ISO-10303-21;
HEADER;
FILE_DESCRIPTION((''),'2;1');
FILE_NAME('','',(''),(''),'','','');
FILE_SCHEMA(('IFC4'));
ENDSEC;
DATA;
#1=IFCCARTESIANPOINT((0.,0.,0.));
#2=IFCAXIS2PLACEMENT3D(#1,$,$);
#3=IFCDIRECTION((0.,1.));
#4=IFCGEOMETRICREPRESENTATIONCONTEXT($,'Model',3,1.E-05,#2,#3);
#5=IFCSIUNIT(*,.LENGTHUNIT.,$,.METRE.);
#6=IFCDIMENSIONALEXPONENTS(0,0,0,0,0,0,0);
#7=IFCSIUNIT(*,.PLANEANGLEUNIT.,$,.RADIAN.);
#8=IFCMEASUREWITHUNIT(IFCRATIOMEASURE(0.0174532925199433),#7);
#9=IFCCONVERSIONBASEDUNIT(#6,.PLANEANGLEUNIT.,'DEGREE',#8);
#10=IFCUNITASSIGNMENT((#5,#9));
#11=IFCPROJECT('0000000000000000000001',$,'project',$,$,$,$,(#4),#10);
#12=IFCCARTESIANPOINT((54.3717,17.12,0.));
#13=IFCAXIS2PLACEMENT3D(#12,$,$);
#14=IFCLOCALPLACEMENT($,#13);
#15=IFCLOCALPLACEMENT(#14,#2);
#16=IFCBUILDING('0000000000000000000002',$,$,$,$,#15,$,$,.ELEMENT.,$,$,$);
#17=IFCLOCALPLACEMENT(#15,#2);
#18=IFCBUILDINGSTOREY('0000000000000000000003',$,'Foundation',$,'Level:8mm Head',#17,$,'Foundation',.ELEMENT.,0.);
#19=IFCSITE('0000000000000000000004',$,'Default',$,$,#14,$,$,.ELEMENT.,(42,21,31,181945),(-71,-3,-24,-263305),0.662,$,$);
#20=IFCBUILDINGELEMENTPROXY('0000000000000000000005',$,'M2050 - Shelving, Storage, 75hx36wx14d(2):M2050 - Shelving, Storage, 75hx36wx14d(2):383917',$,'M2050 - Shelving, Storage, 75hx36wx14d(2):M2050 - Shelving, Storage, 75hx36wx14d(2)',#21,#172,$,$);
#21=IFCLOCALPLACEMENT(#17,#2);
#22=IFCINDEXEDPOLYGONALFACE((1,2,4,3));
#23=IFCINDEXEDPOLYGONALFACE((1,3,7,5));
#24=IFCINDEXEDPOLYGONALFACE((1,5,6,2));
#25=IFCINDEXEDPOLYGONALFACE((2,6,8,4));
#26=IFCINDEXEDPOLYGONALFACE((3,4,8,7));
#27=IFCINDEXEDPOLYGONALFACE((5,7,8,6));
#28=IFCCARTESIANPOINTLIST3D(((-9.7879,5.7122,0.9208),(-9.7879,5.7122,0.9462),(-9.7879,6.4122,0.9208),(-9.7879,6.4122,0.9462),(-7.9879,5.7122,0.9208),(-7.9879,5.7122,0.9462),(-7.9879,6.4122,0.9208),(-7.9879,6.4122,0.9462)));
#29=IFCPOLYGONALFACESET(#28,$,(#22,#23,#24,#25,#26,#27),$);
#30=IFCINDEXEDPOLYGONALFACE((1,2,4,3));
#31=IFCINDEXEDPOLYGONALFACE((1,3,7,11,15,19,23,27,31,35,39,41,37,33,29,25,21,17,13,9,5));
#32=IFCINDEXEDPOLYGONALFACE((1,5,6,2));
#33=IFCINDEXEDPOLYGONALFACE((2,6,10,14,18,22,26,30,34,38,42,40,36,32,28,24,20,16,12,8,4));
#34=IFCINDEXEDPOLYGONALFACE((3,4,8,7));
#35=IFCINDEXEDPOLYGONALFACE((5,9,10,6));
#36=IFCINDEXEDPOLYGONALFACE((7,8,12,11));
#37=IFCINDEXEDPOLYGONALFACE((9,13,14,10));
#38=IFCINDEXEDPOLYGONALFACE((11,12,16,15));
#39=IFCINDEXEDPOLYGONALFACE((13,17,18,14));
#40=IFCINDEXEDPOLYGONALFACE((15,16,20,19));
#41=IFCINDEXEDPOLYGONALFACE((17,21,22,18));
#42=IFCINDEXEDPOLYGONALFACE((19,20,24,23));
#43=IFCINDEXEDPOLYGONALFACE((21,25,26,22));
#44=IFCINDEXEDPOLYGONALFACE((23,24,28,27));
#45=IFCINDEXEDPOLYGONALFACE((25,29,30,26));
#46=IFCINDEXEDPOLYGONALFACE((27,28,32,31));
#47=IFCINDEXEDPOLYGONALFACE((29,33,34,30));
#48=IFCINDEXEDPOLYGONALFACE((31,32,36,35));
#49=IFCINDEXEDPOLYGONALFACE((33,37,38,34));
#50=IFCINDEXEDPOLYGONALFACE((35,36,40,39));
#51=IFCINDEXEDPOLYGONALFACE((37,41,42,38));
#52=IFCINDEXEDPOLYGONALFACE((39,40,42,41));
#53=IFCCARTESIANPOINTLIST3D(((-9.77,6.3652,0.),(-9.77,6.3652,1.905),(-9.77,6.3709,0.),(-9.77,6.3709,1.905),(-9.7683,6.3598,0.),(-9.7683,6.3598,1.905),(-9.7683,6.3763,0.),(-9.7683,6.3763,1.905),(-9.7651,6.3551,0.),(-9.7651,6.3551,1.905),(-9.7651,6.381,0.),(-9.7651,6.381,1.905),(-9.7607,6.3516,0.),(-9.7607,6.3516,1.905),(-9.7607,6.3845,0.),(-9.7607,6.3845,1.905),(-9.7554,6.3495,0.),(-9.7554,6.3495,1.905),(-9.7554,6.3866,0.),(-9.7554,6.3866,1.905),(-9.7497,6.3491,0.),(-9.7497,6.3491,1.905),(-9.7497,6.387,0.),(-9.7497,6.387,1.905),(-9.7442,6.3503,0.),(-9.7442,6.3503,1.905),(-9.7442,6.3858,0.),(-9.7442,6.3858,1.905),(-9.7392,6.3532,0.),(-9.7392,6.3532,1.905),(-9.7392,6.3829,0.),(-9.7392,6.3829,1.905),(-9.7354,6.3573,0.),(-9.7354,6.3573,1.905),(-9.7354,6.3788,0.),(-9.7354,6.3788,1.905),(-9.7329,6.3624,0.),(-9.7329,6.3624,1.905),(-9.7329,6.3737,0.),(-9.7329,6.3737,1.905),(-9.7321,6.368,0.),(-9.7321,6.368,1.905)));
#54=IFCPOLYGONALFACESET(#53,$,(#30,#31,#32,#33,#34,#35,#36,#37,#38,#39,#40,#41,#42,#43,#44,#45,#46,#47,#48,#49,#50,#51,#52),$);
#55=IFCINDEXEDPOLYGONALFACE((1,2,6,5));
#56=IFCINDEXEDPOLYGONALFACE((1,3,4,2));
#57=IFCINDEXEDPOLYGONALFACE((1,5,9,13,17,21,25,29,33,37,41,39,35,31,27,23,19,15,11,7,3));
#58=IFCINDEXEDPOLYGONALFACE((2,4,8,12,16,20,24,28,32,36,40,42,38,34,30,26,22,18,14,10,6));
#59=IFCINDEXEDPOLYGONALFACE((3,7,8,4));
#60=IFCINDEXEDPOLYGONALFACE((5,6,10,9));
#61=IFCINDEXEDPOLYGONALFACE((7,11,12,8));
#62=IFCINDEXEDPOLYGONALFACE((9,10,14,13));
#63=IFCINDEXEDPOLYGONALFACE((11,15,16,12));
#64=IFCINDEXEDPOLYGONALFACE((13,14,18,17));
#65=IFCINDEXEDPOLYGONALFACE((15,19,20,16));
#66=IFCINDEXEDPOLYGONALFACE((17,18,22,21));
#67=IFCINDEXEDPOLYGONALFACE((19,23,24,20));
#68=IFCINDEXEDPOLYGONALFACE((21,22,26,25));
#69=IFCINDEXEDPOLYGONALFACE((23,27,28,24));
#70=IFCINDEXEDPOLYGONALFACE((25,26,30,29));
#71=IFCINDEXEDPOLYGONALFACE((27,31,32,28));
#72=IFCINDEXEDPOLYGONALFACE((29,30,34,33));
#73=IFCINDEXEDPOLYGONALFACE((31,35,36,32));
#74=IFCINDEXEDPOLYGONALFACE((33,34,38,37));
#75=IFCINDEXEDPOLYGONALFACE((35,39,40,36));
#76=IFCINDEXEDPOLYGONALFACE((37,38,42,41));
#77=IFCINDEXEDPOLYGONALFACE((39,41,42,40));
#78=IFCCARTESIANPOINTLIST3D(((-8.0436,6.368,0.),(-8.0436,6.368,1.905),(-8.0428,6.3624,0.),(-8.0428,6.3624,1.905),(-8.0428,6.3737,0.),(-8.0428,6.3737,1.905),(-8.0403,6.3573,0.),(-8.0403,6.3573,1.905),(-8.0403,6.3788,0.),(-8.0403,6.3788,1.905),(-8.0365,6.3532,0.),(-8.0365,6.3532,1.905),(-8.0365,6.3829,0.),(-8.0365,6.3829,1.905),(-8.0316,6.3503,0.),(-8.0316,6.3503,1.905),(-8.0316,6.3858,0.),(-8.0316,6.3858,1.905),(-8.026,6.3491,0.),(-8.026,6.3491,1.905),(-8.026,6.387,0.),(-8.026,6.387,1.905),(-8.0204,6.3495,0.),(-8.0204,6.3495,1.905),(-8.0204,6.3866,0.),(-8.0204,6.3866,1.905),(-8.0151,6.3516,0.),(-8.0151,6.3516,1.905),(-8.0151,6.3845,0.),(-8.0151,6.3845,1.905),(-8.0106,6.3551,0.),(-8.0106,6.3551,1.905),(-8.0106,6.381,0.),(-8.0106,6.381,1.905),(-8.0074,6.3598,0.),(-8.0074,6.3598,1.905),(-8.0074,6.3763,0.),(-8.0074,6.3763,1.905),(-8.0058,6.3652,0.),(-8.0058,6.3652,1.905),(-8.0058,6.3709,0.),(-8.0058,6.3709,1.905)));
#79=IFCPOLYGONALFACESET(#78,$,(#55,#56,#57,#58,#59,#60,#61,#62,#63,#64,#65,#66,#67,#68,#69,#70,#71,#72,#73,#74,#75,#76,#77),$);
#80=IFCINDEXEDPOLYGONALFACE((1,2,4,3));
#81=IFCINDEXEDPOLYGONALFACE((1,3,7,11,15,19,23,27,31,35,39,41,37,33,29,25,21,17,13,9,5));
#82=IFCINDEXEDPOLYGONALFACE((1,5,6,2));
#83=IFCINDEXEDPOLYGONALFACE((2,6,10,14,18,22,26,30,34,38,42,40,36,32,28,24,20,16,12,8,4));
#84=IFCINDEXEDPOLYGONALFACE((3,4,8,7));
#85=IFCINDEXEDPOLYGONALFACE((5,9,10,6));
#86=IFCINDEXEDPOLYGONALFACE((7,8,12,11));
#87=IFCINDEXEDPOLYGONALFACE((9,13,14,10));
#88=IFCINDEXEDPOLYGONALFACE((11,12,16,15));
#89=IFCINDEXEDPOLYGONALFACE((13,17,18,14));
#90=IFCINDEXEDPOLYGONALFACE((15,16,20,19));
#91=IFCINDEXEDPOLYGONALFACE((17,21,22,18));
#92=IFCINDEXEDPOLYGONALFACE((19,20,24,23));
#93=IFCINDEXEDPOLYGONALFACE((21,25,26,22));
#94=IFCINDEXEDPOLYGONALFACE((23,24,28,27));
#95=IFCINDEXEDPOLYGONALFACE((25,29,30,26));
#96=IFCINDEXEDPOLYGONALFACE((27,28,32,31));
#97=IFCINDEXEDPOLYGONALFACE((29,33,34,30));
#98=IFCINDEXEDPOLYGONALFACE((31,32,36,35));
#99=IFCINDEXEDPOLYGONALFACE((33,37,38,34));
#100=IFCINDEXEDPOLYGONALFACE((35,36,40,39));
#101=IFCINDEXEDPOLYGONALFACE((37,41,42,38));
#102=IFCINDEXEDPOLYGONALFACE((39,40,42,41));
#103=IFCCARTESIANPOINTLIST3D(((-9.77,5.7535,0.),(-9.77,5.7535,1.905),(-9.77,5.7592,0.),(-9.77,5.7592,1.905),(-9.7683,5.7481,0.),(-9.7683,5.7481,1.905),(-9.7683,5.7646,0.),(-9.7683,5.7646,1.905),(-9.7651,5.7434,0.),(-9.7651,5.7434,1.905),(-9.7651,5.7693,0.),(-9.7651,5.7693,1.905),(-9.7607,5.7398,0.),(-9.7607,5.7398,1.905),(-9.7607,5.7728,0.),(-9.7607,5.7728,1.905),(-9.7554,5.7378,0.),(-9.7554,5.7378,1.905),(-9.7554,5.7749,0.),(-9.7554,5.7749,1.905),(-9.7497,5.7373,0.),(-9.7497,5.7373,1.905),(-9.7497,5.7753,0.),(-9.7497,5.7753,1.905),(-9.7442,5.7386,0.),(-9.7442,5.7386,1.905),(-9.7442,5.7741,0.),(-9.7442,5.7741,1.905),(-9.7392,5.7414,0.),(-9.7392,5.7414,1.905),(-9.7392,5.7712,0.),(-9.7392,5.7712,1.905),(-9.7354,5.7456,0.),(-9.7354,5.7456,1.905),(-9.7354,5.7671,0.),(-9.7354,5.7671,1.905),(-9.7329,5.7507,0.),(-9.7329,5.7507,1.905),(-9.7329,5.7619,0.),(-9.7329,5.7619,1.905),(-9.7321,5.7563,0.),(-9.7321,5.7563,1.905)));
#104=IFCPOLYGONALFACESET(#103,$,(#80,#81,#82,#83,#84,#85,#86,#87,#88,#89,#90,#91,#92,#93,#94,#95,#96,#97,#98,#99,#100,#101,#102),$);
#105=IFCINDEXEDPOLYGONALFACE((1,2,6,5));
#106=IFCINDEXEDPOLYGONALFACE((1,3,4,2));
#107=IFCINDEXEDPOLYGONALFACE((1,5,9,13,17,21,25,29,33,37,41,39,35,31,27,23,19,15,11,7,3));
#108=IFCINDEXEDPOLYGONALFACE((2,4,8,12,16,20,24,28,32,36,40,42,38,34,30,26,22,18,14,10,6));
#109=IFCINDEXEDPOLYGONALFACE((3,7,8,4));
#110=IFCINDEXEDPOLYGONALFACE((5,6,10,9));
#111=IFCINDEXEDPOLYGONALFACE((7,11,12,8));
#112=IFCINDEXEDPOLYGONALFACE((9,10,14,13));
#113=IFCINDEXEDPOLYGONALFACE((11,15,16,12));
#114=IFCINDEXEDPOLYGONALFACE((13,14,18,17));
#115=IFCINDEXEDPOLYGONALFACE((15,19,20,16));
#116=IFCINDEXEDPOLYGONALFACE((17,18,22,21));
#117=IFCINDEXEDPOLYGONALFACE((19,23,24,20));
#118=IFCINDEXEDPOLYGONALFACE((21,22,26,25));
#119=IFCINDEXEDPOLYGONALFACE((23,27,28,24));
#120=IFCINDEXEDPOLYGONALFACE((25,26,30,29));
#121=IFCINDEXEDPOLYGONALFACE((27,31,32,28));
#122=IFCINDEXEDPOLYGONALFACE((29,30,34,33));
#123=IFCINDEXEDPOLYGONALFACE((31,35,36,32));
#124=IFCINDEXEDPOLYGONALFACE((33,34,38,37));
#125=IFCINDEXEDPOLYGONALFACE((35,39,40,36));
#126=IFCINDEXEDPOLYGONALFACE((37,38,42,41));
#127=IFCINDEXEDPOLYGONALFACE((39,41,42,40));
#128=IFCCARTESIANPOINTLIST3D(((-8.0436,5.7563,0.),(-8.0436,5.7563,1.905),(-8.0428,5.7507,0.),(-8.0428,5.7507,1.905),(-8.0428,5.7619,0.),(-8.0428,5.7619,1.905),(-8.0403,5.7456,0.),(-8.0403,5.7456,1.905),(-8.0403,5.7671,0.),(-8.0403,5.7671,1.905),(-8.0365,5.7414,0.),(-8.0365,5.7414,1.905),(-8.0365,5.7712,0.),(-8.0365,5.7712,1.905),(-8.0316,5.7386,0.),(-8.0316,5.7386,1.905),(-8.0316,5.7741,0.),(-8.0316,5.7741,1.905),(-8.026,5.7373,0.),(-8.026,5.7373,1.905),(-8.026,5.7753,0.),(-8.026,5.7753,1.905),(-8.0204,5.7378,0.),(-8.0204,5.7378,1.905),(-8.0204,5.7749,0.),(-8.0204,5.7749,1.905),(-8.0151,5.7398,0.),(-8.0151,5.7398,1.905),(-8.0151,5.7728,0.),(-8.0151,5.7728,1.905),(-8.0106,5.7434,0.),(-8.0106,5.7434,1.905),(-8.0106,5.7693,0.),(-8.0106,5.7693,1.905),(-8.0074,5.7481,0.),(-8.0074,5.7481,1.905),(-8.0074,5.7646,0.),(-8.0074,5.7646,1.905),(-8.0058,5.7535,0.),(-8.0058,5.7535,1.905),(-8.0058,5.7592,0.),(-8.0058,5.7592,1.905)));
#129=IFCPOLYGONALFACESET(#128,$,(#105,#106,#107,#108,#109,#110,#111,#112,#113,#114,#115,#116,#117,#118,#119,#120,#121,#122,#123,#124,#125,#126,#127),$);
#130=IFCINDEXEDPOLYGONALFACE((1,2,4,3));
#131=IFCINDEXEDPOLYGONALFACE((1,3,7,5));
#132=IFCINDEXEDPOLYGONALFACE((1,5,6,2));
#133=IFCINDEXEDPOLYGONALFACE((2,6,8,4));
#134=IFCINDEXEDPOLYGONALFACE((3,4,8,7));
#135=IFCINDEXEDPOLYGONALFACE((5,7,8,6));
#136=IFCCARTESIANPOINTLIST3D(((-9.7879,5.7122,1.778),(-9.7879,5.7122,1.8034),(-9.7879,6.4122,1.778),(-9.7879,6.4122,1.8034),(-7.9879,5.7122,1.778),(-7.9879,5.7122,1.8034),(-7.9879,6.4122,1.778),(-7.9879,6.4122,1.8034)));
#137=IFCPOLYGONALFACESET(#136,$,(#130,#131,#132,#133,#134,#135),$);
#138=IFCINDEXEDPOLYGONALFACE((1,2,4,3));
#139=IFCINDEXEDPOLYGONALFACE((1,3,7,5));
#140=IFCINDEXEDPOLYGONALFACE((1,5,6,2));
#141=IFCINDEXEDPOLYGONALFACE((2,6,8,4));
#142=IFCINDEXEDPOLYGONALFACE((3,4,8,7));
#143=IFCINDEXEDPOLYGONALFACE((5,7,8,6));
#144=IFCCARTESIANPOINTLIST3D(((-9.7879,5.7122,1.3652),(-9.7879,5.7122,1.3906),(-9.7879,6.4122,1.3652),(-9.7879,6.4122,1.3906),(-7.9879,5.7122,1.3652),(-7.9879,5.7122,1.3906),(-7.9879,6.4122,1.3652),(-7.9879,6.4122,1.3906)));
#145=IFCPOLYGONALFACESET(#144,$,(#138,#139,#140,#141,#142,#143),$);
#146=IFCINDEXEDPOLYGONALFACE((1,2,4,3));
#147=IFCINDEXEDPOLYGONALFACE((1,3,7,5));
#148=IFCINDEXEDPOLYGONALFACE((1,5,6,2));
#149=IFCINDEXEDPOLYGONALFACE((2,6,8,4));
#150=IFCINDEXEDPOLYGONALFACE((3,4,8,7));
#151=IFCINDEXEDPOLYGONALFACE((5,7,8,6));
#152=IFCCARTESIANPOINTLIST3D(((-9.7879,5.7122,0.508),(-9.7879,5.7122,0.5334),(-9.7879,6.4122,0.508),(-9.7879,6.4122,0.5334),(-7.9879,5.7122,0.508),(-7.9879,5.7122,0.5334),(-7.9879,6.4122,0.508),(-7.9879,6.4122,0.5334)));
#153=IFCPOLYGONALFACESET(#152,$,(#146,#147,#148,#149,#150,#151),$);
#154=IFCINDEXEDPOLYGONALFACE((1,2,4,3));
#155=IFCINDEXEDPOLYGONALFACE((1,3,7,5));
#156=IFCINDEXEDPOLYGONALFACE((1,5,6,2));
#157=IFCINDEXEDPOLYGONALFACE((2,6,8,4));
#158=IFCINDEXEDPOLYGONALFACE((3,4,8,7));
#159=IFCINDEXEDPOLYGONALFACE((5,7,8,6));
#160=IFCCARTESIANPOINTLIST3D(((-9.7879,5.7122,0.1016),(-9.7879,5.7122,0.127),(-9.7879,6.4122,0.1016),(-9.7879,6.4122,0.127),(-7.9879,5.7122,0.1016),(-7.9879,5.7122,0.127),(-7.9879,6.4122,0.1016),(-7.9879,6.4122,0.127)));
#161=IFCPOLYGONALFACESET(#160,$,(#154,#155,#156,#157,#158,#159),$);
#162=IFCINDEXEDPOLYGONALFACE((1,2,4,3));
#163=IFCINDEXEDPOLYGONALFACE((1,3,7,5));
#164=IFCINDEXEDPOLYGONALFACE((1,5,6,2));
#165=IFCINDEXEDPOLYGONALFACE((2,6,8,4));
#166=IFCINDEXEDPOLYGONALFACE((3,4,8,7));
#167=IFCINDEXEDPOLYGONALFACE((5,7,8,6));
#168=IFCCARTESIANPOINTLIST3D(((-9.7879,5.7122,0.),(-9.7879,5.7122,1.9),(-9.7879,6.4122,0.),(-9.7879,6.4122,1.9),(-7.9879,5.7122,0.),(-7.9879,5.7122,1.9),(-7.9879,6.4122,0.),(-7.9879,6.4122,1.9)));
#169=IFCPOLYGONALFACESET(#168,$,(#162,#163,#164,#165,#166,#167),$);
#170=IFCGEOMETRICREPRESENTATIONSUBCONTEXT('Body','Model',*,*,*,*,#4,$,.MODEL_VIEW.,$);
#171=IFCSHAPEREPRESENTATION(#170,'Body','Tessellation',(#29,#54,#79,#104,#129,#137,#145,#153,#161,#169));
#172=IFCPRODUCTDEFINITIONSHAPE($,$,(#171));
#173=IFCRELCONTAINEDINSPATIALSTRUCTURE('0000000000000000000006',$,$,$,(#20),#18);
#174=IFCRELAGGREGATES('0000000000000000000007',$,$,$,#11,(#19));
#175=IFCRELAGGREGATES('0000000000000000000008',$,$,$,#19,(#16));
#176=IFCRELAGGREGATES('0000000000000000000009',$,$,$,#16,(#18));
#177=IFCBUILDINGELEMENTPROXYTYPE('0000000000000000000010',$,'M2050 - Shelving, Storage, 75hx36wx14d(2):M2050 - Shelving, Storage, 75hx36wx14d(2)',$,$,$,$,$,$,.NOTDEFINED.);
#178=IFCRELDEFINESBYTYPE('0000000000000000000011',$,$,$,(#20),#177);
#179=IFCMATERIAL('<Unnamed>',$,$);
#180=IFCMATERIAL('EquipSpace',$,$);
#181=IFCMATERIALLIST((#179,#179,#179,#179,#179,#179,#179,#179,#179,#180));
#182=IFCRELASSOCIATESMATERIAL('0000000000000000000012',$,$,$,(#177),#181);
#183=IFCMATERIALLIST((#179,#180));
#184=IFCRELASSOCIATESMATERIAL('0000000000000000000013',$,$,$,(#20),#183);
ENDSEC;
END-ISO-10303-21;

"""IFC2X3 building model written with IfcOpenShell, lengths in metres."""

from ifc_helpers import new_model, entity, si_unit, converted_unit, direction, frame, frame_2d, origin, origin_2d_with_axis, place, context, subcontext, project, spatial, rectangle, circle, extrude, source, transform, mapped, material, material_list, type_object, type_shapes, element, save


model = new_model("IFC2X3")

# Units and contexts
model_context = context("Model", 3, precision=1e-05, world=origin(), true_north=direction((0.0, 1.0)))
body_context = subcontext(model_context, "Body", "Model", "MODEL_VIEW")
ifc_project = project(units=[si_unit("LENGTHUNIT", "METRE"), converted_unit("PLANEANGLEUNIT", "DEGREE", entity("IfcRatioMeasure", 0.0174532925199433), si_unit("PLANEANGLEUNIT", "RADIAN"), dimensions=[0, 0, 0, 0, 0, 0, 0])], contexts=[model_context])

# Site, building, storey
site_placement = place(None, frame((54.3717, 17.12, 0.0)))
site = spatial("IfcSite", under=ifc_project, at=site_placement, Name="Default", CompositionType="ELEMENT", RefLatitude=(42, 21, 31, 181945), RefLongitude=(-71, -3, -24, -263305), RefElevation=0.662)
building_placement = place(site_placement, origin())
building = spatial("IfcBuilding", under=site, at=building_placement, CompositionType="ELEMENT")
storey_placement = place(building_placement, origin())
storey = spatial("IfcBuildingStorey", under=building, at=storey_placement, Name="Foundation", ObjectType="Level:8mm Head", LongName="Foundation", CompositionType="ELEMENT", Elevation=0.0)

# Building element proxy
ifc_material_1 = material(Name="<Unnamed>")
ifc_material_2 = material(Name="EquipSpace")
ifc_material_list_1 = material_list([ifc_material_1, ifc_material_1, ifc_material_1, ifc_material_1, ifc_material_1, ifc_material_1, ifc_material_1, ifc_material_1, ifc_material_1, ifc_material_2])
building_element_proxy_type = type_object("IfcBuildingElementProxyType", Name="M2050 - Shelving, Storage, 75hx36wx14d(2):M2050 - Shelving, Storage, 75hx36wx14d(2)", PredefinedType="NOTDEFINED", material=ifc_material_list_1)
shared_shape = source(origin(), body_context, "Body", "SweptSolid", [
    extrude(rectangle(XDim=1.8, YDim=0.7, at=origin_2d_with_axis()), frame((0.0, 0.0, 0.9207), z_axis=(0.0, 0.0, 1.0), x_axis=(-1.0, 0.0, 0.0)), (0.0, 0.0, 1.0), 0.0254),
    extrude(circle(Radius=0.0191, at=origin_2d_with_axis()), frame((0.8633, -0.3059, 0.0), z_axis=(0.0, 0.0, 1.0), x_axis=(-1.0, 0.0, 0.0)), (0.0, 0.0, 1.0), 1.905),
    extrude(circle(Radius=0.0191, at=origin_2d_with_axis()), frame((-0.8633, -0.3059, 0.0)), (0.0, 0.0, 1.0), 1.905),
    extrude(circle(Radius=0.0191, at=origin_2d_with_axis()), frame((0.8633, 0.3059, 0.0), z_axis=(0.0, 0.0, 1.0), x_axis=(-1.0, 0.0, 0.0)), (0.0, 0.0, 1.0), 1.905),
    extrude(circle(Radius=0.0191, at=origin_2d_with_axis()), frame((-0.8633, 0.3059, 0.0)), (0.0, 0.0, 1.0), 1.905),
    extrude(rectangle(XDim=1.8, YDim=0.7, at=origin_2d_with_axis()), frame((0.0, 0.0, 1.778), z_axis=(0.0, 0.0, 1.0), x_axis=(-1.0, 0.0, 0.0)), (0.0, 0.0, 1.0), 0.0254),
    extrude(rectangle(XDim=1.8, YDim=0.7, at=origin_2d_with_axis()), frame((0.0, 0.0, 1.3653), z_axis=(0.0, 0.0, 1.0), x_axis=(-1.0, 0.0, 0.0)), (0.0, 0.0, 1.0), 0.0254),
    extrude(rectangle(XDim=1.8, YDim=0.7, at=origin_2d_with_axis()), frame((0.0, 0.0, 0.508), z_axis=(0.0, 0.0, 1.0), x_axis=(-1.0, 0.0, 0.0)), (0.0, 0.0, 1.0), 0.0254),
    extrude(rectangle(XDim=1.8, YDim=0.7, at=origin_2d_with_axis()), frame((0.0, 0.0, 0.1016), z_axis=(0.0, 0.0, 1.0), x_axis=(-1.0, 0.0, 0.0)), (0.0, 0.0, 1.0), 0.0254),
    extrude(rectangle(XDim=0.7, YDim=1.8, at=frame_2d((0.0, 0.18), x_axis=(1.0, 0.0))), frame((-0.18, 0.0, 0.0), z_axis=(0.0, 0.0, 1.0), x_axis=(0.0, -1.0, 0.0)), (0.0, 0.0, 1.0), 1.9),
])
type_shapes(building_element_proxy_type, [shared_shape])
ifc_material_list_2 = material_list([ifc_material_1, ifc_material_2])
proxy_1_placement = place(storey_placement, frame((-8.8879, 6.0622, 0.0), z_axis=(0.0, 0.0, 1.0), x_axis=(-1.0, 0.0, 0.0)))
element("IfcBuildingElementProxy", 1, at=proxy_1_placement, inside=storey, type_object=building_element_proxy_type, material=ifc_material_list_2, Name="M2050 - Shelving, Storage, 75hx36wx14d(2):M2050 - Shelving, Storage, 75hx36wx14d(2):383917", ObjectType="M2050 - Shelving, Storage, 75hx36wx14d(2):M2050 - Shelving, Storage, 75hx36wx14d(2)", context=body_context, shape_type="MappedRepresentation", body=[
    mapped(shared_shape, transform((0.0, 0.0, 0.0), scale=1.0)),
])

save(model, "model.ifc")
